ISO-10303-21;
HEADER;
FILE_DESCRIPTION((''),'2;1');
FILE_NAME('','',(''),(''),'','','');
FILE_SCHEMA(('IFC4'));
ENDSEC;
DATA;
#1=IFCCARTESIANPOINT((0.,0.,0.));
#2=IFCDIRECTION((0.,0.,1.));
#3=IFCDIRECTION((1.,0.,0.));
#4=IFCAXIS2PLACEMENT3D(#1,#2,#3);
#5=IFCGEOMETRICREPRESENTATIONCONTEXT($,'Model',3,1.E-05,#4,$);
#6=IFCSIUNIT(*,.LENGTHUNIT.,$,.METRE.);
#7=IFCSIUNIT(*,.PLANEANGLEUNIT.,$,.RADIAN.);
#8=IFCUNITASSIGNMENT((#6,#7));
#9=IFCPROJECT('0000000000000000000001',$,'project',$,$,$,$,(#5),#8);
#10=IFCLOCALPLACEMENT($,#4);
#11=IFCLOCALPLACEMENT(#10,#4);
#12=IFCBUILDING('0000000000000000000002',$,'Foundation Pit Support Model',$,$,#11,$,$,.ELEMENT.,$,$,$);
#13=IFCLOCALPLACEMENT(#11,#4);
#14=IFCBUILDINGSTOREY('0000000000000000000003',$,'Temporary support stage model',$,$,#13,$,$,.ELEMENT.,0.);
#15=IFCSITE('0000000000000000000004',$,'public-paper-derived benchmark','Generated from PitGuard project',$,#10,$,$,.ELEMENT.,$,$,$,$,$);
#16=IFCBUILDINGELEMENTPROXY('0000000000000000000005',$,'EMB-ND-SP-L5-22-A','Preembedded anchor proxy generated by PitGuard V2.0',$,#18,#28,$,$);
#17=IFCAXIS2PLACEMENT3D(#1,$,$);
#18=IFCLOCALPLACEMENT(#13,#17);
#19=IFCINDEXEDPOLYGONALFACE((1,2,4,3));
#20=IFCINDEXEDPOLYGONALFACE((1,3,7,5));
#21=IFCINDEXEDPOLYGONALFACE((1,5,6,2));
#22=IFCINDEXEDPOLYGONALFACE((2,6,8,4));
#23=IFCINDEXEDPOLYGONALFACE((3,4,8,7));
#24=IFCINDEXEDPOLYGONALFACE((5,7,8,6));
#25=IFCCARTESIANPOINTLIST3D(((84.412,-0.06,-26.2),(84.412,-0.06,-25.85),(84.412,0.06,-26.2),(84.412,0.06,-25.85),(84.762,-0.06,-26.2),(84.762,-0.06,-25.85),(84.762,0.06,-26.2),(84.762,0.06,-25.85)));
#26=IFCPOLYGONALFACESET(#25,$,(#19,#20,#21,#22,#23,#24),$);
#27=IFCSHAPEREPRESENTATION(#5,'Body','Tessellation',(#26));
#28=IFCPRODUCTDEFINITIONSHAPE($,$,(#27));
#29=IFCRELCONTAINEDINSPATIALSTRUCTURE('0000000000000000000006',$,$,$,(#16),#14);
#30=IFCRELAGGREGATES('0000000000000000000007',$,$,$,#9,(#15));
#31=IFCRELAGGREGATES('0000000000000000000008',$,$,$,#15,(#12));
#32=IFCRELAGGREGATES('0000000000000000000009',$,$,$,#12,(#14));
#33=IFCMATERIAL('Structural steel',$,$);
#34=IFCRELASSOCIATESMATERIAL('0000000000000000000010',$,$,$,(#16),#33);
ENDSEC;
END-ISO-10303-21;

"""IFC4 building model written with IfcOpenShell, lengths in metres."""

from ifc_helpers import new_model, si_unit, frame, origin_with_axes, origin_2d, place, context, project, spatial, rectangle, extrude, material, element, save


model = new_model("IFC4")

# Units and contexts
model_context = context("Model", 3, precision=1e-05, world=origin_with_axes())
ifc_project = project(units=[si_unit("LENGTHUNIT", "METRE"), si_unit("PLANEANGLEUNIT", "RADIAN")], contexts=[model_context])

# Site, building, storey
site_placement = place(None, origin_with_axes())
site = spatial("IfcSite", under=ifc_project, at=site_placement, Name="public-paper-derived benchmark", Description="Generated from PitGuard project", CompositionType="ELEMENT")
building_placement = place(site_placement, origin_with_axes())
building = spatial("IfcBuilding", under=site, at=building_placement, Name="Foundation Pit Support Model", CompositionType="ELEMENT")
storey_placement = place(building_placement, origin_with_axes())
storey = spatial("IfcBuildingStorey", under=building, at=storey_placement, Name="Temporary support stage model", CompositionType="ELEMENT", Elevation=0.0)

# Shared definitions
ifc_material_1 = material(Name="Structural steel")

# Building element proxy
proxy_1_placement = place(storey_placement, frame((84.587, 0.0, -26.2), z_axis=(0.0, 0.0, 1.0), x_axis=(1.0, 0.0, 0.0)))
element("IfcBuildingElementProxy", 1, at=proxy_1_placement, inside=storey, material=ifc_material_1, Name="EMB-ND-SP-L5-22-A", Description="Preembedded anchor proxy generated by PitGuard V2.0", context=model_context, shape_type="SweptSolid", body=[
    extrude(rectangle(XDim=0.35, YDim=0.12, at=origin_2d()), origin_with_axes(), (0.0, 0.0, 1.0), 0.35),
])

save(model, "model.ifc")
